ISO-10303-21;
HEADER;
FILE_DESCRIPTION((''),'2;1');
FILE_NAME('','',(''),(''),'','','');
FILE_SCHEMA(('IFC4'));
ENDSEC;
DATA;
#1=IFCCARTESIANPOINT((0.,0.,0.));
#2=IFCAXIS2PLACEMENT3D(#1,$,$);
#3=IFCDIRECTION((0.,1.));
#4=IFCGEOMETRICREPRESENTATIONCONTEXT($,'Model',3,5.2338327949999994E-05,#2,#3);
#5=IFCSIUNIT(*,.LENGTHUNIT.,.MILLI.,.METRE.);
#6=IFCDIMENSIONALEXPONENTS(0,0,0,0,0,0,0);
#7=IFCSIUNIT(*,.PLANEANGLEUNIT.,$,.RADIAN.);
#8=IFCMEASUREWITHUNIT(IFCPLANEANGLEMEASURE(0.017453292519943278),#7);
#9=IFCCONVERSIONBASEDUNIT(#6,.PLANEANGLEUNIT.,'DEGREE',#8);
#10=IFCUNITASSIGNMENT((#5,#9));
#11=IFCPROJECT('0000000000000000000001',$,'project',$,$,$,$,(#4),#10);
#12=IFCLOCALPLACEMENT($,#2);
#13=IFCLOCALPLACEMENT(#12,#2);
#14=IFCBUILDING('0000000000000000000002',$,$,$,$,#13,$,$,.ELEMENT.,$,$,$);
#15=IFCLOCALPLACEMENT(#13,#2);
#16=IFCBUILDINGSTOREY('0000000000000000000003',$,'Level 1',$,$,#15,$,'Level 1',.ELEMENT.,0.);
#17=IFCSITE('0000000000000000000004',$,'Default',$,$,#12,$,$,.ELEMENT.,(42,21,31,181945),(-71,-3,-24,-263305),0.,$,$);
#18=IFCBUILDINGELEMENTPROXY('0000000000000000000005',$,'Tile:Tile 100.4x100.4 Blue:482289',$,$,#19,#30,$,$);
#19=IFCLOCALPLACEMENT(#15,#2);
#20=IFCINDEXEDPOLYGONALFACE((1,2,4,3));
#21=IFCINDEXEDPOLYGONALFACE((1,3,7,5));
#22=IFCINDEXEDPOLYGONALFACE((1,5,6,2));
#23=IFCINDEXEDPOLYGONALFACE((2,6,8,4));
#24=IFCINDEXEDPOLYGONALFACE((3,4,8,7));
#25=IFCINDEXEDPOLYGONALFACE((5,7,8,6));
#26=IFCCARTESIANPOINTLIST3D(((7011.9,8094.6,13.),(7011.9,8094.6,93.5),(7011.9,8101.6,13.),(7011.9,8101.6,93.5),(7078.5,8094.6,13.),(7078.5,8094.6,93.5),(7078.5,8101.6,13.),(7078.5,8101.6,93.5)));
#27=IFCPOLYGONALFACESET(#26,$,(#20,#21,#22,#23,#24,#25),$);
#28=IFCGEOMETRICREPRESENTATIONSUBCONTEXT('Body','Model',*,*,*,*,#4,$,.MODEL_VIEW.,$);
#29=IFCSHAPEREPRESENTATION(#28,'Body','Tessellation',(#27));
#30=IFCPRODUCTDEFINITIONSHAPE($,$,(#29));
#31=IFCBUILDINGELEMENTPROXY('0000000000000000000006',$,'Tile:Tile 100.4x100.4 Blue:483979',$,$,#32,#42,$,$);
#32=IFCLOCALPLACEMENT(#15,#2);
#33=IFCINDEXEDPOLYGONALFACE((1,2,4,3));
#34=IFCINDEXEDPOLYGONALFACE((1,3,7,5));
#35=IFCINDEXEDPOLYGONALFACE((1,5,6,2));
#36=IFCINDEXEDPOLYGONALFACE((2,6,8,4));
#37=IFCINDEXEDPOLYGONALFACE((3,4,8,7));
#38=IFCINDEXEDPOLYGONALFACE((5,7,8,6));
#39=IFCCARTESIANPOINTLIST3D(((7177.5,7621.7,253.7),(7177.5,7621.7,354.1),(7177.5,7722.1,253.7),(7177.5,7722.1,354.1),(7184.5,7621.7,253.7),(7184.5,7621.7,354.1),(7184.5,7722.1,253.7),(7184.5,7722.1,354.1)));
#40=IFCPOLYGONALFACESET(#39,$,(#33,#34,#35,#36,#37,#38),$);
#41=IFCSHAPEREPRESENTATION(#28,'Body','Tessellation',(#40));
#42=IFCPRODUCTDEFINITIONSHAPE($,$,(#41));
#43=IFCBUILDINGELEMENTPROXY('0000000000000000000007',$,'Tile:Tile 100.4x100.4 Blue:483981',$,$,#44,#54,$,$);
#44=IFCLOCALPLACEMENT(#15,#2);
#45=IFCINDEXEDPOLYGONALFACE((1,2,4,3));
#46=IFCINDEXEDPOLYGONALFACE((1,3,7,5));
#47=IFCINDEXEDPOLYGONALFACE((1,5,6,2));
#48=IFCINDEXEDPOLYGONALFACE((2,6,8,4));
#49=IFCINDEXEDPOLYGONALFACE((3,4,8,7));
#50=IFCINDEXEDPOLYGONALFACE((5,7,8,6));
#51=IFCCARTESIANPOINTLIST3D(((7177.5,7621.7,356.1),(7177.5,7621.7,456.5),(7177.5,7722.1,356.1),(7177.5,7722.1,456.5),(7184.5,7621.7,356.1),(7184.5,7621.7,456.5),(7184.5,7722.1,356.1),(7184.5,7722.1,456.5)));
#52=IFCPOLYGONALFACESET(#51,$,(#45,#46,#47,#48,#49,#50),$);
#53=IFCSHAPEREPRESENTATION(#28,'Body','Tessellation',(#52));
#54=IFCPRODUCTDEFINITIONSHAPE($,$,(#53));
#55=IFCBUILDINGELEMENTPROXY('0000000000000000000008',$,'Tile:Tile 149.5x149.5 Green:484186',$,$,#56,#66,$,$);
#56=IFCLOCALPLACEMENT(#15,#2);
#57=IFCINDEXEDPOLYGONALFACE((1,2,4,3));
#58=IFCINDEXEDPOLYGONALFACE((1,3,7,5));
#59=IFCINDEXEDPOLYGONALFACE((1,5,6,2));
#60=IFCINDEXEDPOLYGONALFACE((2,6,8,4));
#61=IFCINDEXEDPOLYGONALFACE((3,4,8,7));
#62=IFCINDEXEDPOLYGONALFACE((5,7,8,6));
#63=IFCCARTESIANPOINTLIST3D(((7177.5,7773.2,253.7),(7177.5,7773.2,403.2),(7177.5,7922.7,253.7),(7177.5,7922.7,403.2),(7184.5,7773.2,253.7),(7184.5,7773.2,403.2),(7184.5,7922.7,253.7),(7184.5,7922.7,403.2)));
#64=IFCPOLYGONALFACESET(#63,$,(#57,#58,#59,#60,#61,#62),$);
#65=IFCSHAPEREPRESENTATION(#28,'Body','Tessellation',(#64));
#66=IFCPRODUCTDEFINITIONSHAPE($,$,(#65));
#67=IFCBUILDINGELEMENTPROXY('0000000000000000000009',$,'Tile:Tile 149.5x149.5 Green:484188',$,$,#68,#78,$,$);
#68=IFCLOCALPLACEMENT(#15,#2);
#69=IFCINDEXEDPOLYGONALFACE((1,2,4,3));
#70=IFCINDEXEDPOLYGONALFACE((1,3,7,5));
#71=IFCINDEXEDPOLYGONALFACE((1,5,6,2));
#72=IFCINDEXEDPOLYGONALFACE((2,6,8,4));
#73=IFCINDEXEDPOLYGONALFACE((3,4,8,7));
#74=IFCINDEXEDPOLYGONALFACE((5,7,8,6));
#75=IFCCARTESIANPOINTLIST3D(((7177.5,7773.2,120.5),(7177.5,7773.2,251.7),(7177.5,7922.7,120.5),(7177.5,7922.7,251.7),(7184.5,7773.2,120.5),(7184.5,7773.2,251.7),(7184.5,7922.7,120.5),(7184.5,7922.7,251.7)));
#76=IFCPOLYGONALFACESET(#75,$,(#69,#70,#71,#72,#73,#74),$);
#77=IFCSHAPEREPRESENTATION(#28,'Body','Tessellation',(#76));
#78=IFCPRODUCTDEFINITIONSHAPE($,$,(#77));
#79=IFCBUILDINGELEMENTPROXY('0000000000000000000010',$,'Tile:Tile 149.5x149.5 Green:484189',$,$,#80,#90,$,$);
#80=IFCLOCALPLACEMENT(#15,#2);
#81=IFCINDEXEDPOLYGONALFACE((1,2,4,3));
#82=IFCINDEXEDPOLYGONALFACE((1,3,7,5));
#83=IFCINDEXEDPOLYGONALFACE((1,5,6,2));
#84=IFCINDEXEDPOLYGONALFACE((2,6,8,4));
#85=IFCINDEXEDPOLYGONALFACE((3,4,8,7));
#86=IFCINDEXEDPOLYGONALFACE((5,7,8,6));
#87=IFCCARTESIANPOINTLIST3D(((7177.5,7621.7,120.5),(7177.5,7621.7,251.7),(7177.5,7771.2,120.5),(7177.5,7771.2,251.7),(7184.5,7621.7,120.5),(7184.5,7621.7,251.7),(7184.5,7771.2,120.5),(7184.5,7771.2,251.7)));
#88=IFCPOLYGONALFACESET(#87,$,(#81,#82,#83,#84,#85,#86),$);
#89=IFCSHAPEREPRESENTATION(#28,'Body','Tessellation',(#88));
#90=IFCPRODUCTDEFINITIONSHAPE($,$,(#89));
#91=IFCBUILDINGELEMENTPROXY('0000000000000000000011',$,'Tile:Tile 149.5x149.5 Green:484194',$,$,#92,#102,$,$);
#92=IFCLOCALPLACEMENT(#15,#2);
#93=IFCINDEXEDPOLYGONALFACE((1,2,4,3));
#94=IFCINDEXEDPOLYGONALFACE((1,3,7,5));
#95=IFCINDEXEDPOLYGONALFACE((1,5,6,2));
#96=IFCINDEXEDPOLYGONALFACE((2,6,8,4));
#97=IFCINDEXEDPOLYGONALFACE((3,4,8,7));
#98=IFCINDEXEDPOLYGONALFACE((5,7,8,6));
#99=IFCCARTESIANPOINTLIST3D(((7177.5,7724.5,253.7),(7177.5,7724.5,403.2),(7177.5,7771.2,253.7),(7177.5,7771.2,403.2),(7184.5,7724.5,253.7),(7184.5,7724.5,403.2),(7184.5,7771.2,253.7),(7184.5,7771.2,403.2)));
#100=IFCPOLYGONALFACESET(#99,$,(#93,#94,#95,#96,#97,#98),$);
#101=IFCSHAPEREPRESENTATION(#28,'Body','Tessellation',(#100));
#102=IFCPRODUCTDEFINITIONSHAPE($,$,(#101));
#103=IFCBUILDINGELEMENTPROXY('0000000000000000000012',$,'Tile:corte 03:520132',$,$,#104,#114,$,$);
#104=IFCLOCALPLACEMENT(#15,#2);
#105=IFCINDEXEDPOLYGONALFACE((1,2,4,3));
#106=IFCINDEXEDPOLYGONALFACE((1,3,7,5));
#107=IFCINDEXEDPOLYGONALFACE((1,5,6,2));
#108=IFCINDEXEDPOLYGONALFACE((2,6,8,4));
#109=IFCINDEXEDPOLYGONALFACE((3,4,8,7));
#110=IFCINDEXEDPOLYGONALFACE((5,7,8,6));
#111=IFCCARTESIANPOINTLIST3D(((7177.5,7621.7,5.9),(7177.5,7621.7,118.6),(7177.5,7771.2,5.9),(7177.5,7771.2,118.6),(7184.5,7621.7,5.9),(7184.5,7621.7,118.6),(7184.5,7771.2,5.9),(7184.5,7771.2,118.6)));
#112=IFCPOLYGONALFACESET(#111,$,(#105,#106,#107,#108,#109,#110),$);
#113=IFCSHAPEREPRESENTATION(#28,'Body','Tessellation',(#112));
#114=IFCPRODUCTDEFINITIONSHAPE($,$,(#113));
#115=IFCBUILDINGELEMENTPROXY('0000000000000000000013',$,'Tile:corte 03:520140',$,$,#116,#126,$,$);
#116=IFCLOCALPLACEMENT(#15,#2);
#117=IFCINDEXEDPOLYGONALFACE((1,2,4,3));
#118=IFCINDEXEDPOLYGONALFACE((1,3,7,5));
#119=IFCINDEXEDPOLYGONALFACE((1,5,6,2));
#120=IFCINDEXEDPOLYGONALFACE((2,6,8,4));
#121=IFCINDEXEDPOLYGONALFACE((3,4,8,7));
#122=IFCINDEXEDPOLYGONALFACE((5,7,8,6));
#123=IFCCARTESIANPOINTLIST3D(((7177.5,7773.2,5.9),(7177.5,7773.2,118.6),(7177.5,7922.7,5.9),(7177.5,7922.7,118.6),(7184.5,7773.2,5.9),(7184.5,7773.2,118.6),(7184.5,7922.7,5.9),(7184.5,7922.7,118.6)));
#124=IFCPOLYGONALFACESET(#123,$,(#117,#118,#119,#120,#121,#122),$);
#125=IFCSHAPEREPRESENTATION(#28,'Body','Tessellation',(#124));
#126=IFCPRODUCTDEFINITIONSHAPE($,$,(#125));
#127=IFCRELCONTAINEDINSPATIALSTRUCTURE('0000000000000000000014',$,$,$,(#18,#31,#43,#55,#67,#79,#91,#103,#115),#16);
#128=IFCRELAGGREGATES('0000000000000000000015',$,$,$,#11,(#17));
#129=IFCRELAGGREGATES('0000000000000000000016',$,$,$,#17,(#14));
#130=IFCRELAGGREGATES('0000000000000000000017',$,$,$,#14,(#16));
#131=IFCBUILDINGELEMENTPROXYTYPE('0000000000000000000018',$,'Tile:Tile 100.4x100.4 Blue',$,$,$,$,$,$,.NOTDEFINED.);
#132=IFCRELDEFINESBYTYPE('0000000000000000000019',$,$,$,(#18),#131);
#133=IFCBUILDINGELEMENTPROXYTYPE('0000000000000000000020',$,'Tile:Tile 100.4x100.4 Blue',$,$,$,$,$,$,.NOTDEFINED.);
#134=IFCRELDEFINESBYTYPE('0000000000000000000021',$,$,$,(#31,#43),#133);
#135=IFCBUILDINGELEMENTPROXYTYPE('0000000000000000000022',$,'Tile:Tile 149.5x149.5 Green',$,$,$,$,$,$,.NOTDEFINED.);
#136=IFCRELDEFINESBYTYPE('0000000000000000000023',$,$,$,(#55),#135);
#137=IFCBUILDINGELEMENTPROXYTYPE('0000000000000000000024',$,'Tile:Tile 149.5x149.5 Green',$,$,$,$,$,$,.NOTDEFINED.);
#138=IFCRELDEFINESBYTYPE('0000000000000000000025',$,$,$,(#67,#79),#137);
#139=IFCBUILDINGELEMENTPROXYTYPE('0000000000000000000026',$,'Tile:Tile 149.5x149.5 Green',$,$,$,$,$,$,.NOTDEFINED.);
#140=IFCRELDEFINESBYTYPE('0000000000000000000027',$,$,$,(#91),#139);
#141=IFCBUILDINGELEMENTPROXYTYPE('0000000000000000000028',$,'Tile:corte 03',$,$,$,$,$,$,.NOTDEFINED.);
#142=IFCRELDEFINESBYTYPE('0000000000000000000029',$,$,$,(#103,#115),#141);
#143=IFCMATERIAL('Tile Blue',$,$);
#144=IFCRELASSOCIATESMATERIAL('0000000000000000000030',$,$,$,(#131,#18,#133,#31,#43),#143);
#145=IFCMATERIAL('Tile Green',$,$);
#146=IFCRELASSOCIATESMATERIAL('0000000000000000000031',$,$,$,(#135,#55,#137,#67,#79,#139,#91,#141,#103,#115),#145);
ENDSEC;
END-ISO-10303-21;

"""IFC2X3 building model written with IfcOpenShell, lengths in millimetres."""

from ifc_helpers import new_model, entity, si_unit, converted_unit, direction, frame, origin, origin_2d_with_axis, place, context, subcontext, project, spatial, rectangle, extrude, source, transform, mapped, material, type_object, type_shapes, element, save


model = new_model("IFC2X3")

# Units and contexts
model_context = context("Model", 3, precision=5.2338327949999994e-05, world=origin(), true_north=direction((0.0, 1.0)))
body_context = subcontext(model_context, "Body", "Model", "MODEL_VIEW")
ifc_project = project(units=[si_unit("LENGTHUNIT", "METRE", prefix="MILLI"), converted_unit("PLANEANGLEUNIT", "DEGREE", entity("IfcPlaneAngleMeasure", 0.017453292519943278), si_unit("PLANEANGLEUNIT", "RADIAN"), dimensions=[0, 0, 0, 0, 0, 0, 0])], contexts=[model_context])

# Site, building, storey
site_placement = place(None, origin())
site = spatial("IfcSite", under=ifc_project, at=site_placement, Name="Default", CompositionType="ELEMENT", RefLatitude=(42, 21, 31, 181945), RefLongitude=(-71, -3, -24, -263305), RefElevation=0.0)
building_placement = place(site_placement, origin())
building = spatial("IfcBuilding", under=site, at=building_placement, CompositionType="ELEMENT")
storey_placement = place(building_placement, origin())
storey = spatial("IfcBuildingStorey", under=building, at=storey_placement, Name="Level 1", LongName="Level 1", CompositionType="ELEMENT", Elevation=0.0)

# Building element proxies
ifc_material_1 = material(Name="Tile Blue")
building_element_proxy_type_1 = type_object("IfcBuildingElementProxyType", Name="Tile:Tile 100.4x100.4 Blue", PredefinedType="NOTDEFINED", material=ifc_material_1)
shared_shape_1 = source(origin(), body_context, "Body", "SweptSolid", [
    extrude(rectangle(XDim=66.6, YDim=80.5, at=origin_2d_with_axis()), frame((-33.3, -40.3, 0.0), z_axis=(0.0, 0.0, 1.0), x_axis=(-1.0, 0.0, 0.0)), (0.0, 0.0, 1.0), 7.0),
])
type_shapes(building_element_proxy_type_1, [shared_shape_1])
proxy_1_placement = place(storey_placement, frame((7011.9, 8101.6, 13.0), z_axis=(0.0, -1.0, 0.0), x_axis=(-1.0, 0.0, 0.0)))
element("IfcBuildingElementProxy", 1, at=proxy_1_placement, inside=storey, type_object=building_element_proxy_type_1, material=ifc_material_1, Name="Tile:Tile 100.4x100.4 Blue:482289", context=body_context, shape_type="MappedRepresentation", body=[
    mapped(shared_shape_1, transform((0.0, 0.0, 0.0), scale=1.0)),
])
building_element_proxy_type_2 = type_object("IfcBuildingElementProxyType", Name="Tile:Tile 100.4x100.4 Blue", PredefinedType="NOTDEFINED", material=ifc_material_1)
shared_shape_2 = source(origin(), body_context, "Body", "SweptSolid", [
    extrude(rectangle(XDim=100.4, YDim=100.4, at=origin_2d_with_axis()), frame((-50.2, -50.2, 0.0), z_axis=(0.0, 0.0, 1.0), x_axis=(0.0, -1.0, 0.0)), (0.0, 0.0, 1.0), 7.0),
])
type_shapes(building_element_proxy_type_2, [shared_shape_2])
for number, where, z_axis, x_axis, name in (
    (2, (7184.5, 7722.1, 253.7), (-1.0, 0.0, 0.0), (0.0, 1.0, 0.0), "Tile:Tile 100.4x100.4 Blue:483979"),
    (3, (7184.5, 7722.1, 356.1), (-1.0, 0.0, 0.0), (0.0, 1.0, 0.0), "Tile:Tile 100.4x100.4 Blue:483981"),
):
    element("IfcBuildingElementProxy", number, at=place(storey_placement, frame(where, z_axis=z_axis, x_axis=x_axis)), inside=storey, type_object=building_element_proxy_type_2, material=ifc_material_1, Name=name, context=body_context, shape_type="MappedRepresentation", body=[
        mapped(shared_shape_2, transform((0.0, 0.0, 0.0), scale=1.0)),
    ])
ifc_material_2 = material(Name="Tile Green")
building_element_proxy_type_3 = type_object("IfcBuildingElementProxyType", Name="Tile:Tile 149.5x149.5 Green", PredefinedType="NOTDEFINED", material=ifc_material_2)
shared_shape_3 = source(origin(), body_context, "Body", "SweptSolid", [
    extrude(rectangle(XDim=149.5, YDim=149.5, at=origin_2d_with_axis()), frame((-74.7, -74.8, 0.0), z_axis=(0.0, 0.0, 1.0), x_axis=(0.0, -1.0, 0.0)), (0.0, 0.0, 1.0), 7.0),
])
type_shapes(building_element_proxy_type_3, [shared_shape_3])
proxy_2_placement = place(storey_placement, frame((7184.5, 7922.7, 403.2), z_axis=(-1.0, 0.0, 0.0), x_axis=(0.0, 0.0, 1.0)))
element("IfcBuildingElementProxy", 4, at=proxy_2_placement, inside=storey, type_object=building_element_proxy_type_3, material=ifc_material_2, Name="Tile:Tile 149.5x149.5 Green:484186", context=body_context, shape_type="MappedRepresentation", body=[
    mapped(shared_shape_3, transform((0.0, 0.0, 0.0), scale=1.0)),
])
building_element_proxy_type_4 = type_object("IfcBuildingElementProxyType", Name="Tile:Tile 149.5x149.5 Green", PredefinedType="NOTDEFINED", material=ifc_material_2)
shared_shape_4 = source(origin(), body_context, "Body", "SweptSolid", [
    extrude(rectangle(XDim=131.2, YDim=149.5, at=origin_2d_with_axis()), frame((-65.6, -74.8, 0.0), z_axis=(0.0, 0.0, 1.0), x_axis=(-1.0, 0.0, 0.0)), (0.0, 0.0, 1.0), 7.0),
])
type_shapes(building_element_proxy_type_4, [shared_shape_4])
for number, where, z_axis, x_axis, name in (
    (5, (7184.5, 7922.7, 251.7), (-1.0, 0.0, 0.0), (0.0, 0.0, 1.0), "Tile:Tile 149.5x149.5 Green:484188"),
    (6, (7184.5, 7771.2, 251.7), (-1.0, 0.0, 0.0), (0.0, 0.0, 1.0), "Tile:Tile 149.5x149.5 Green:484189"),
):
    element("IfcBuildingElementProxy", number, at=place(storey_placement, frame(where, z_axis=z_axis, x_axis=x_axis)), inside=storey, type_object=building_element_proxy_type_4, material=ifc_material_2, Name=name, context=body_context, shape_type="MappedRepresentation", body=[
        mapped(shared_shape_4, transform((0.0, 0.0, 0.0), scale=1.0)),
    ])
building_element_proxy_type_5 = type_object("IfcBuildingElementProxyType", Name="Tile:Tile 149.5x149.5 Green", PredefinedType="NOTDEFINED", material=ifc_material_2)
shared_shape_5 = source(origin(), body_context, "Body", "SweptSolid", [
    extrude(rectangle(XDim=46.7, YDim=149.5, at=origin_2d_with_axis()), frame((-23.3, -74.8, 0.0), z_axis=(0.0, 0.0, 1.0), x_axis=(-1.0, 0.0, 0.0)), (0.0, 0.0, 1.0), 7.0),
])
type_shapes(building_element_proxy_type_5, [shared_shape_5])
proxy_3_placement = place(storey_placement, frame((7184.5, 7771.2, 253.7), z_axis=(-1.0, 0.0, 0.0), x_axis=(0.0, 1.0, 0.0)))
element("IfcBuildingElementProxy", 7, at=proxy_3_placement, inside=storey, type_object=building_element_proxy_type_5, material=ifc_material_2, Name="Tile:Tile 149.5x149.5 Green:484194", context=body_context, shape_type="MappedRepresentation", body=[
    mapped(shared_shape_5, transform((0.0, 0.0, 0.0), scale=1.0)),
])
building_element_proxy_type_6 = type_object("IfcBuildingElementProxyType", Name="Tile:corte 03", PredefinedType="NOTDEFINED", material=ifc_material_2)
shared_shape_6 = source(origin(), body_context, "Body", "SweptSolid", [
    extrude(rectangle(XDim=112.7, YDim=149.5, at=origin_2d_with_axis()), frame((-56.3, -74.8, 0.0), z_axis=(0.0, 0.0, 1.0), x_axis=(-1.0, 0.0, 0.0)), (0.0, 0.0, 1.0), 7.0),
])
type_shapes(building_element_proxy_type_6, [shared_shape_6])
for number, where, z_axis, x_axis, name in (
    (8, (7184.5, 7771.2, 118.6), (-1.0, 0.0, 0.0), (0.0, 0.0, 1.0), "Tile:corte 03:520132"),
    (9, (7184.5, 7922.7, 118.6), (-1.0, 0.0, 0.0), (0.0, 0.0, 1.0), "Tile:corte 03:520140"),
):
    element("IfcBuildingElementProxy", number, at=place(storey_placement, frame(where, z_axis=z_axis, x_axis=x_axis)), inside=storey, type_object=building_element_proxy_type_6, material=ifc_material_2, Name=name, context=body_context, shape_type="MappedRepresentation", body=[
        mapped(shared_shape_6, transform((0.0, 0.0, 0.0), scale=1.0)),
    ])

save(model, "model.ifc")
